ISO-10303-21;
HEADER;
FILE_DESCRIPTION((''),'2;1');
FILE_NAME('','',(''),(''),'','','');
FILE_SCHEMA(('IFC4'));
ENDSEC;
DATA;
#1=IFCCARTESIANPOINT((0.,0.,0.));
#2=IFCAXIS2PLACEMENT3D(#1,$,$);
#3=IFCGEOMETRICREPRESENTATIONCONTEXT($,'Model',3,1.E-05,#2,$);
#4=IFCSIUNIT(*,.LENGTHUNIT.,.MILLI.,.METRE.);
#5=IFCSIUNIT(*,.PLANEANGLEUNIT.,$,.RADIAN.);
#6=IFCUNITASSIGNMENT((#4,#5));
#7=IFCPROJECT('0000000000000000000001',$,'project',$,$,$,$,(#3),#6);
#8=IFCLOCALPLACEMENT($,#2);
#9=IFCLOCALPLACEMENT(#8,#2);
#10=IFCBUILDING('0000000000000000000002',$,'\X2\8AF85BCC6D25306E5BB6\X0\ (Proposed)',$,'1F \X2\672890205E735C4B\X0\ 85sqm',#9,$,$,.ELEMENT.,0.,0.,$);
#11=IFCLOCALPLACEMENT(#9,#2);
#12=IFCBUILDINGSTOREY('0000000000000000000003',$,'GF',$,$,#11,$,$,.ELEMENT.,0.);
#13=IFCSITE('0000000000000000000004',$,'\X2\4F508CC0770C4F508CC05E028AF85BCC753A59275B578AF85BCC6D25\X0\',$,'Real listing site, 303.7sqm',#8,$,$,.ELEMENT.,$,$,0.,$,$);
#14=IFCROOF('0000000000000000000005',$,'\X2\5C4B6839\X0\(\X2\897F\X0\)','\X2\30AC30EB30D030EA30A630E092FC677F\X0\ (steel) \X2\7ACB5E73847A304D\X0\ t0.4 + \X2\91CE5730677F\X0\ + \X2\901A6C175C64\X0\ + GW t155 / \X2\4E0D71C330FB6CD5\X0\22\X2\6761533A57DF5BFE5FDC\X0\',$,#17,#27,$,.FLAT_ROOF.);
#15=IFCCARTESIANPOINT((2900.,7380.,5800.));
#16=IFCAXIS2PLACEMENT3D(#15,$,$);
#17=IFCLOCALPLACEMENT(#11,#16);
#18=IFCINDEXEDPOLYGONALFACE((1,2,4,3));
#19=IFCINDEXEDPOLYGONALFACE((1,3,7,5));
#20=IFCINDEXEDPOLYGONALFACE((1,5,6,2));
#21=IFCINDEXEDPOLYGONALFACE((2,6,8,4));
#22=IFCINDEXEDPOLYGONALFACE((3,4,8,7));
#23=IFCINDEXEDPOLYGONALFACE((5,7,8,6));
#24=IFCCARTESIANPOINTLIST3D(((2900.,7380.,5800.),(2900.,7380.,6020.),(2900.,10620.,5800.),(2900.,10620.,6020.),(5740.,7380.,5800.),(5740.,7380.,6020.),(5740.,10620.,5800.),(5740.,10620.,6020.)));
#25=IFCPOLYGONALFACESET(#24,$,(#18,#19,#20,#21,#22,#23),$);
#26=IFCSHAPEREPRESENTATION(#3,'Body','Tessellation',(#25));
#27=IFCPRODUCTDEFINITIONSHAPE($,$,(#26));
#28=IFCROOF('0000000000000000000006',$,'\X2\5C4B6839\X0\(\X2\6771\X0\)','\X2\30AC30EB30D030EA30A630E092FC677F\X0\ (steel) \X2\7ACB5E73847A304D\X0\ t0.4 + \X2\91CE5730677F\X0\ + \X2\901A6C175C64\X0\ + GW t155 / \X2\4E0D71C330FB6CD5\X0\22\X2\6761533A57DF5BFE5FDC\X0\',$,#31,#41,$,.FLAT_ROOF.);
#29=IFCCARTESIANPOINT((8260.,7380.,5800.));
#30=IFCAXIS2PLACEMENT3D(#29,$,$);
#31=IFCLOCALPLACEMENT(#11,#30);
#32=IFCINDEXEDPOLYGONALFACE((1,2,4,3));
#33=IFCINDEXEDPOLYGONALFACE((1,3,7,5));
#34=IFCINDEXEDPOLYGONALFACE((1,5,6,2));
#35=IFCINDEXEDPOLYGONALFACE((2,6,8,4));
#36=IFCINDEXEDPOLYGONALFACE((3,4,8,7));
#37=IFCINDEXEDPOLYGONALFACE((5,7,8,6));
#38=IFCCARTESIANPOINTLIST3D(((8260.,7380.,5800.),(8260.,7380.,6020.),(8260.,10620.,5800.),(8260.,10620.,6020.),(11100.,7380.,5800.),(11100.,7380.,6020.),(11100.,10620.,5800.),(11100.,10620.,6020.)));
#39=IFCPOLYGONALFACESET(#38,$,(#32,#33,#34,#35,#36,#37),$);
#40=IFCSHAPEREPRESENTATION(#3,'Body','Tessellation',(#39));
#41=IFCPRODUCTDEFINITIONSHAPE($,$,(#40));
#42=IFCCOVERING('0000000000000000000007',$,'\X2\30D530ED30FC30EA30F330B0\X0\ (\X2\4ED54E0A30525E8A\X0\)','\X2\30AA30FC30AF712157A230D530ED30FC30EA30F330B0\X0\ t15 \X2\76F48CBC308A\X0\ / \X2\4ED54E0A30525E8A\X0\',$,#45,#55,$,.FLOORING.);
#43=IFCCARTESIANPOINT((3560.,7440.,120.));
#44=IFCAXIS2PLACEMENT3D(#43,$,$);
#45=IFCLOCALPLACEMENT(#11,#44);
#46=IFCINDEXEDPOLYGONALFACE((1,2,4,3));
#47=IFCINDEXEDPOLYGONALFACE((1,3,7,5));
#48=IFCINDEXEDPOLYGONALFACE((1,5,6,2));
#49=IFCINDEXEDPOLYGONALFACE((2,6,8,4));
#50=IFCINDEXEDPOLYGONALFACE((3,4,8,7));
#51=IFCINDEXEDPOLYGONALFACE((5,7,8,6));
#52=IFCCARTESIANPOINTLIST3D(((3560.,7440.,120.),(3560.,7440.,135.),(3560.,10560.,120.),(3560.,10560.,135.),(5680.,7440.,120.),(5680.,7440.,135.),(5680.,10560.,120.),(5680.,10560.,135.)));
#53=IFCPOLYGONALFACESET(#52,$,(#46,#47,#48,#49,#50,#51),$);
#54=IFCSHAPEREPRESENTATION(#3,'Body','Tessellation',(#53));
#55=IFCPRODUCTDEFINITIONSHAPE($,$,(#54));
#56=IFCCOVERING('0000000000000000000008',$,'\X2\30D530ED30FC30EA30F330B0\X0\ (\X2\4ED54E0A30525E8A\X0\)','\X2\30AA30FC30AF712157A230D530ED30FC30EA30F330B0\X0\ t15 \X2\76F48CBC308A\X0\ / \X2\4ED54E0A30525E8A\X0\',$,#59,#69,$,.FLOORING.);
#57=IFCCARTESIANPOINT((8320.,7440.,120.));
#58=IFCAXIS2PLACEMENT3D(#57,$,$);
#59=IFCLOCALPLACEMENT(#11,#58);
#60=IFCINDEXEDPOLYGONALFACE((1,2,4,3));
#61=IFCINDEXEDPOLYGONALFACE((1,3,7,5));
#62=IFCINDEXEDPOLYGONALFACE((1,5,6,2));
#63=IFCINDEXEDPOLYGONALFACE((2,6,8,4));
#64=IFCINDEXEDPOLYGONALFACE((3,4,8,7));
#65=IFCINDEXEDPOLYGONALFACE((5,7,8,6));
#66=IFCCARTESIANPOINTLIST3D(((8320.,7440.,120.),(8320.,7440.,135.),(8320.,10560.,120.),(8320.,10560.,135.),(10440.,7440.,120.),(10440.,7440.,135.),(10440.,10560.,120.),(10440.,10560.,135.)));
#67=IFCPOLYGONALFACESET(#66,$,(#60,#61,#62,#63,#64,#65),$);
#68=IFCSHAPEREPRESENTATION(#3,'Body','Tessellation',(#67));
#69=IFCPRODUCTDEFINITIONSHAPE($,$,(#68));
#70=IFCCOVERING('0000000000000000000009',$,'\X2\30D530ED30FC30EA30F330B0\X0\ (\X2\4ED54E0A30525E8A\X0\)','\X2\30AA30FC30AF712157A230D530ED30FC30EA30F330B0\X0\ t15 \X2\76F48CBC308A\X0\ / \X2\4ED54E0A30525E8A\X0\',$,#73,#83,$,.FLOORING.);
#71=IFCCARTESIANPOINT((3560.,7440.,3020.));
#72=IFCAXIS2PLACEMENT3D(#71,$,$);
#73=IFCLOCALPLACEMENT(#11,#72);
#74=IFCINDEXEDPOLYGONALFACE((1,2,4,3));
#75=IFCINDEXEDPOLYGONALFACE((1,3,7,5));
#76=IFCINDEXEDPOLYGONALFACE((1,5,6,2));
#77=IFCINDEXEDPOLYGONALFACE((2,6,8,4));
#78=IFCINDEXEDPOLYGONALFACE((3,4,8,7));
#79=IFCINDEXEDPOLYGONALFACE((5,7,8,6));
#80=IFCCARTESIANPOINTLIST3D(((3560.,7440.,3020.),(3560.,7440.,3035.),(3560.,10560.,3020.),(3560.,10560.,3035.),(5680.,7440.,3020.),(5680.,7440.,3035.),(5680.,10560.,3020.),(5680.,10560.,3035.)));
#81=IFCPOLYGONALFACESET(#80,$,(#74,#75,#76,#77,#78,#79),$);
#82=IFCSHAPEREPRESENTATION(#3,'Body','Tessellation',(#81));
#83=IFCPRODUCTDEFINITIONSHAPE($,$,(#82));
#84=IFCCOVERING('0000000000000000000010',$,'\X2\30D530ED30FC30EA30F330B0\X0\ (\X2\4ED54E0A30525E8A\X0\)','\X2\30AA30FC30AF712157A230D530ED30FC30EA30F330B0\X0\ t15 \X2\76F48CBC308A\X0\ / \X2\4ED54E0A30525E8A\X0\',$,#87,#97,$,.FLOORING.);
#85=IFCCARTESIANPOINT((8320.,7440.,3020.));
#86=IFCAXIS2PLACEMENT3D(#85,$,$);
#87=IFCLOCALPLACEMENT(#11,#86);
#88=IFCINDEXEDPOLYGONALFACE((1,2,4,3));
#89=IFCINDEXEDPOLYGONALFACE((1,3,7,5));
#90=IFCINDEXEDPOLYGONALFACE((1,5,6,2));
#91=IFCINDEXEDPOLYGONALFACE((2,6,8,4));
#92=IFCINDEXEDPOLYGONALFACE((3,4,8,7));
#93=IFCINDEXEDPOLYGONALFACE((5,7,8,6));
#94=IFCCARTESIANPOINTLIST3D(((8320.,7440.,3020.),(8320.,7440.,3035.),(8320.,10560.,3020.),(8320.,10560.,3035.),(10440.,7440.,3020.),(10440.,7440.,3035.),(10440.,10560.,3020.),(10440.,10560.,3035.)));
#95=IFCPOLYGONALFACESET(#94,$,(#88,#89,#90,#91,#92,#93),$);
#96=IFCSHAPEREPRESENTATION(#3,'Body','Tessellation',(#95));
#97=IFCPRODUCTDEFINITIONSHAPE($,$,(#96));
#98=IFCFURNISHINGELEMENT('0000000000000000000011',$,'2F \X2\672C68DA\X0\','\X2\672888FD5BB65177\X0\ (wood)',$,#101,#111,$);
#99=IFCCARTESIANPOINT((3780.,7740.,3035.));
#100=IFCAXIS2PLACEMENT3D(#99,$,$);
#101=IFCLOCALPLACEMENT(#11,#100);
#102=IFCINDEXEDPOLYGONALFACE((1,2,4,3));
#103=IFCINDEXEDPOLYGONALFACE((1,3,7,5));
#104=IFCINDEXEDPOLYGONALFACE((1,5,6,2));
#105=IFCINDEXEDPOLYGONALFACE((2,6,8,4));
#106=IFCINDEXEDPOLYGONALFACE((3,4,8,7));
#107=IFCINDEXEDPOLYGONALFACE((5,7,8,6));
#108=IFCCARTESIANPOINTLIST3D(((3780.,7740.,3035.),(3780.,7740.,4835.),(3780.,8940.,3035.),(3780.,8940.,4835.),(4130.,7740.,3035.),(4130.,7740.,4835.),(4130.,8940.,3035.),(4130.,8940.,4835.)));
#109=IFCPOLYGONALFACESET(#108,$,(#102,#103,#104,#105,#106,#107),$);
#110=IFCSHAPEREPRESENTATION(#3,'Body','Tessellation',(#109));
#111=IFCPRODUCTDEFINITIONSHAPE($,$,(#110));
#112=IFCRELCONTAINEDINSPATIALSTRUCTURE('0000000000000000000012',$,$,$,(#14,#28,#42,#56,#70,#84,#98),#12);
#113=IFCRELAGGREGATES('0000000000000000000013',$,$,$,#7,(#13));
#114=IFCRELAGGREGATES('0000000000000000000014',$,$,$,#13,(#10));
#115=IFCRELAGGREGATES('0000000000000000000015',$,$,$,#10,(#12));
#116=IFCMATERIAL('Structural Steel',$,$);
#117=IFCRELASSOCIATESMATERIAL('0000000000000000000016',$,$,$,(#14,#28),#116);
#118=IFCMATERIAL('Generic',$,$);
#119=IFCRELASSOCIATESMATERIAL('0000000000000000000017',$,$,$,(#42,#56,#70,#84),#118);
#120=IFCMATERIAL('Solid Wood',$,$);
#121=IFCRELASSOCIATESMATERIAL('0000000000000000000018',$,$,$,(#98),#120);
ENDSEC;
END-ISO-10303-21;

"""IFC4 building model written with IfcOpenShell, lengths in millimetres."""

from ifc_helpers import new_model, si_unit, frame, frame_2d, origin, place, context, project, spatial, rectangle, extrude, material, element, save


model = new_model("IFC4")

# Units and contexts
model_context = context("Model", 3, precision=1e-05, world=origin())
ifc_project = project(units=[si_unit("LENGTHUNIT", "METRE", prefix="MILLI"), si_unit("PLANEANGLEUNIT", "RADIAN")], contexts=[model_context])

# Site, building, storey
site_placement = place(None, origin())
site = spatial("IfcSite", under=ifc_project, at=site_placement, Name="佐賀県佐賀市諸富町大字諸富津", ObjectType="Real listing site, 303.7sqm", CompositionType="ELEMENT", RefElevation=0.0)
building_placement = place(site_placement, origin())
building = spatial("IfcBuilding", under=site, at=building_placement, Name="諸富津の家 (Proposed)", ObjectType="1F 木造平屋 85sqm", CompositionType="ELEMENT", ElevationOfRefHeight=0.0, ElevationOfTerrain=0.0)
storey_placement = place(building_placement, origin())
storey = spatial("IfcBuildingStorey", under=building, at=storey_placement, Name="GF", CompositionType="ELEMENT", Elevation=0.0)

# Shared definitions
ifc_material_1 = material(Name="Solid Wood")

# Roofs
ifc_material_2 = material(Name="Structural Steel")
roof_1_placement = place(storey_placement, frame((2900.0, 7380.0, 5800.0)))
element("IfcRoof", 1, at=roof_1_placement, inside=storey, material=ifc_material_2, Name="屋根(西)", Description="ガルバリウム鋼板 (steel) 立平葺き t0.4 + 野地板 + 通気層 + GW t155 / 不燃・法22条区域対応", PredefinedType="FLAT_ROOF", context=model_context, shape_type="SweptSolid", body=[
    extrude(rectangle(XDim=2840.0, YDim=3240.0, at=frame_2d((1420.0, 1620.0))), frame((2900.0, 7380.0, 5800.0)), (0.0, 0.0, 1.0), 220.0),
])
roof_2_placement = place(storey_placement, frame((8260.0, 7380.0, 5800.0)))
element("IfcRoof", 2, at=roof_2_placement, inside=storey, material=ifc_material_2, Name="屋根(東)", Description="ガルバリウム鋼板 (steel) 立平葺き t0.4 + 野地板 + 通気層 + GW t155 / 不燃・法22条区域対応", PredefinedType="FLAT_ROOF", context=model_context, shape_type="SweptSolid", body=[
    extrude(rectangle(XDim=2840.0, YDim=3240.0, at=frame_2d((1420.0, 1620.0))), frame((8260.0, 7380.0, 5800.0)), (0.0, 0.0, 1.0), 220.0),
])

# Coverings
ifc_material_3 = material(Name="Generic")
covering_1_placement = place(storey_placement, frame((3560.0, 7440.0, 120.0)))
element("IfcCovering", 3, at=covering_1_placement, inside=storey, material=ifc_material_3, Name="フローリング (仕上げ床)", Description="オーク無垢フローリング t15 直貼り / 仕上げ床", PredefinedType="FLOORING", context=model_context, shape_type="SweptSolid", body=[
    extrude(rectangle(XDim=2120.0, YDim=3120.0, at=frame_2d((1060.0, 1560.0))), frame((3560.0, 7440.0, 120.0)), (0.0, 0.0, 1.0), 15.0),
])
covering_2_placement = place(storey_placement, frame((8320.0, 7440.0, 120.0)))
element("IfcCovering", 4, at=covering_2_placement, inside=storey, material=ifc_material_3, Name="フローリング (仕上げ床)", Description="オーク無垢フローリング t15 直貼り / 仕上げ床", PredefinedType="FLOORING", context=model_context, shape_type="SweptSolid", body=[
    extrude(rectangle(XDim=2120.0, YDim=3120.0, at=frame_2d((1060.0, 1560.0))), frame((8320.0, 7440.0, 120.0)), (0.0, 0.0, 1.0), 15.0),
])
covering_3_placement = place(storey_placement, frame((3560.0, 7440.0, 3020.0)))
element("IfcCovering", 5, at=covering_3_placement, inside=storey, material=ifc_material_3, Name="フローリング (仕上げ床)", Description="オーク無垢フローリング t15 直貼り / 仕上げ床", PredefinedType="FLOORING", context=model_context, shape_type="SweptSolid", body=[
    extrude(rectangle(XDim=2120.0, YDim=3120.0, at=frame_2d((1060.0, 1560.0))), frame((3560.0, 7440.0, 3020.0)), (0.0, 0.0, 1.0), 15.0),
])
covering_4_placement = place(storey_placement, frame((8320.0, 7440.0, 3020.0)))
element("IfcCovering", 6, at=covering_4_placement, inside=storey, material=ifc_material_3, Name="フローリング (仕上げ床)", Description="オーク無垢フローリング t15 直貼り / 仕上げ床", PredefinedType="FLOORING", context=model_context, shape_type="SweptSolid", body=[
    extrude(rectangle(XDim=2120.0, YDim=3120.0, at=frame_2d((1060.0, 1560.0))), frame((8320.0, 7440.0, 3020.0)), (0.0, 0.0, 1.0), 15.0),
])

# Furnishing element
furnishing_placement = place(storey_placement, frame((3780.0, 7740.0, 3035.0)))
element("IfcFurnishingElement", 7, at=furnishing_placement, inside=storey, material=ifc_material_1, Name="2F 本棚", Description="木製家具 (wood)", context=model_context, shape_type="SweptSolid", body=[
    extrude(rectangle(XDim=350.0, YDim=1200.0, at=frame_2d((175.0, 600.0))), frame((3780.0, 7740.0, 3035.0)), (0.0, 0.0, 1.0), 1800.0),
])

save(model, "model.ifc")
